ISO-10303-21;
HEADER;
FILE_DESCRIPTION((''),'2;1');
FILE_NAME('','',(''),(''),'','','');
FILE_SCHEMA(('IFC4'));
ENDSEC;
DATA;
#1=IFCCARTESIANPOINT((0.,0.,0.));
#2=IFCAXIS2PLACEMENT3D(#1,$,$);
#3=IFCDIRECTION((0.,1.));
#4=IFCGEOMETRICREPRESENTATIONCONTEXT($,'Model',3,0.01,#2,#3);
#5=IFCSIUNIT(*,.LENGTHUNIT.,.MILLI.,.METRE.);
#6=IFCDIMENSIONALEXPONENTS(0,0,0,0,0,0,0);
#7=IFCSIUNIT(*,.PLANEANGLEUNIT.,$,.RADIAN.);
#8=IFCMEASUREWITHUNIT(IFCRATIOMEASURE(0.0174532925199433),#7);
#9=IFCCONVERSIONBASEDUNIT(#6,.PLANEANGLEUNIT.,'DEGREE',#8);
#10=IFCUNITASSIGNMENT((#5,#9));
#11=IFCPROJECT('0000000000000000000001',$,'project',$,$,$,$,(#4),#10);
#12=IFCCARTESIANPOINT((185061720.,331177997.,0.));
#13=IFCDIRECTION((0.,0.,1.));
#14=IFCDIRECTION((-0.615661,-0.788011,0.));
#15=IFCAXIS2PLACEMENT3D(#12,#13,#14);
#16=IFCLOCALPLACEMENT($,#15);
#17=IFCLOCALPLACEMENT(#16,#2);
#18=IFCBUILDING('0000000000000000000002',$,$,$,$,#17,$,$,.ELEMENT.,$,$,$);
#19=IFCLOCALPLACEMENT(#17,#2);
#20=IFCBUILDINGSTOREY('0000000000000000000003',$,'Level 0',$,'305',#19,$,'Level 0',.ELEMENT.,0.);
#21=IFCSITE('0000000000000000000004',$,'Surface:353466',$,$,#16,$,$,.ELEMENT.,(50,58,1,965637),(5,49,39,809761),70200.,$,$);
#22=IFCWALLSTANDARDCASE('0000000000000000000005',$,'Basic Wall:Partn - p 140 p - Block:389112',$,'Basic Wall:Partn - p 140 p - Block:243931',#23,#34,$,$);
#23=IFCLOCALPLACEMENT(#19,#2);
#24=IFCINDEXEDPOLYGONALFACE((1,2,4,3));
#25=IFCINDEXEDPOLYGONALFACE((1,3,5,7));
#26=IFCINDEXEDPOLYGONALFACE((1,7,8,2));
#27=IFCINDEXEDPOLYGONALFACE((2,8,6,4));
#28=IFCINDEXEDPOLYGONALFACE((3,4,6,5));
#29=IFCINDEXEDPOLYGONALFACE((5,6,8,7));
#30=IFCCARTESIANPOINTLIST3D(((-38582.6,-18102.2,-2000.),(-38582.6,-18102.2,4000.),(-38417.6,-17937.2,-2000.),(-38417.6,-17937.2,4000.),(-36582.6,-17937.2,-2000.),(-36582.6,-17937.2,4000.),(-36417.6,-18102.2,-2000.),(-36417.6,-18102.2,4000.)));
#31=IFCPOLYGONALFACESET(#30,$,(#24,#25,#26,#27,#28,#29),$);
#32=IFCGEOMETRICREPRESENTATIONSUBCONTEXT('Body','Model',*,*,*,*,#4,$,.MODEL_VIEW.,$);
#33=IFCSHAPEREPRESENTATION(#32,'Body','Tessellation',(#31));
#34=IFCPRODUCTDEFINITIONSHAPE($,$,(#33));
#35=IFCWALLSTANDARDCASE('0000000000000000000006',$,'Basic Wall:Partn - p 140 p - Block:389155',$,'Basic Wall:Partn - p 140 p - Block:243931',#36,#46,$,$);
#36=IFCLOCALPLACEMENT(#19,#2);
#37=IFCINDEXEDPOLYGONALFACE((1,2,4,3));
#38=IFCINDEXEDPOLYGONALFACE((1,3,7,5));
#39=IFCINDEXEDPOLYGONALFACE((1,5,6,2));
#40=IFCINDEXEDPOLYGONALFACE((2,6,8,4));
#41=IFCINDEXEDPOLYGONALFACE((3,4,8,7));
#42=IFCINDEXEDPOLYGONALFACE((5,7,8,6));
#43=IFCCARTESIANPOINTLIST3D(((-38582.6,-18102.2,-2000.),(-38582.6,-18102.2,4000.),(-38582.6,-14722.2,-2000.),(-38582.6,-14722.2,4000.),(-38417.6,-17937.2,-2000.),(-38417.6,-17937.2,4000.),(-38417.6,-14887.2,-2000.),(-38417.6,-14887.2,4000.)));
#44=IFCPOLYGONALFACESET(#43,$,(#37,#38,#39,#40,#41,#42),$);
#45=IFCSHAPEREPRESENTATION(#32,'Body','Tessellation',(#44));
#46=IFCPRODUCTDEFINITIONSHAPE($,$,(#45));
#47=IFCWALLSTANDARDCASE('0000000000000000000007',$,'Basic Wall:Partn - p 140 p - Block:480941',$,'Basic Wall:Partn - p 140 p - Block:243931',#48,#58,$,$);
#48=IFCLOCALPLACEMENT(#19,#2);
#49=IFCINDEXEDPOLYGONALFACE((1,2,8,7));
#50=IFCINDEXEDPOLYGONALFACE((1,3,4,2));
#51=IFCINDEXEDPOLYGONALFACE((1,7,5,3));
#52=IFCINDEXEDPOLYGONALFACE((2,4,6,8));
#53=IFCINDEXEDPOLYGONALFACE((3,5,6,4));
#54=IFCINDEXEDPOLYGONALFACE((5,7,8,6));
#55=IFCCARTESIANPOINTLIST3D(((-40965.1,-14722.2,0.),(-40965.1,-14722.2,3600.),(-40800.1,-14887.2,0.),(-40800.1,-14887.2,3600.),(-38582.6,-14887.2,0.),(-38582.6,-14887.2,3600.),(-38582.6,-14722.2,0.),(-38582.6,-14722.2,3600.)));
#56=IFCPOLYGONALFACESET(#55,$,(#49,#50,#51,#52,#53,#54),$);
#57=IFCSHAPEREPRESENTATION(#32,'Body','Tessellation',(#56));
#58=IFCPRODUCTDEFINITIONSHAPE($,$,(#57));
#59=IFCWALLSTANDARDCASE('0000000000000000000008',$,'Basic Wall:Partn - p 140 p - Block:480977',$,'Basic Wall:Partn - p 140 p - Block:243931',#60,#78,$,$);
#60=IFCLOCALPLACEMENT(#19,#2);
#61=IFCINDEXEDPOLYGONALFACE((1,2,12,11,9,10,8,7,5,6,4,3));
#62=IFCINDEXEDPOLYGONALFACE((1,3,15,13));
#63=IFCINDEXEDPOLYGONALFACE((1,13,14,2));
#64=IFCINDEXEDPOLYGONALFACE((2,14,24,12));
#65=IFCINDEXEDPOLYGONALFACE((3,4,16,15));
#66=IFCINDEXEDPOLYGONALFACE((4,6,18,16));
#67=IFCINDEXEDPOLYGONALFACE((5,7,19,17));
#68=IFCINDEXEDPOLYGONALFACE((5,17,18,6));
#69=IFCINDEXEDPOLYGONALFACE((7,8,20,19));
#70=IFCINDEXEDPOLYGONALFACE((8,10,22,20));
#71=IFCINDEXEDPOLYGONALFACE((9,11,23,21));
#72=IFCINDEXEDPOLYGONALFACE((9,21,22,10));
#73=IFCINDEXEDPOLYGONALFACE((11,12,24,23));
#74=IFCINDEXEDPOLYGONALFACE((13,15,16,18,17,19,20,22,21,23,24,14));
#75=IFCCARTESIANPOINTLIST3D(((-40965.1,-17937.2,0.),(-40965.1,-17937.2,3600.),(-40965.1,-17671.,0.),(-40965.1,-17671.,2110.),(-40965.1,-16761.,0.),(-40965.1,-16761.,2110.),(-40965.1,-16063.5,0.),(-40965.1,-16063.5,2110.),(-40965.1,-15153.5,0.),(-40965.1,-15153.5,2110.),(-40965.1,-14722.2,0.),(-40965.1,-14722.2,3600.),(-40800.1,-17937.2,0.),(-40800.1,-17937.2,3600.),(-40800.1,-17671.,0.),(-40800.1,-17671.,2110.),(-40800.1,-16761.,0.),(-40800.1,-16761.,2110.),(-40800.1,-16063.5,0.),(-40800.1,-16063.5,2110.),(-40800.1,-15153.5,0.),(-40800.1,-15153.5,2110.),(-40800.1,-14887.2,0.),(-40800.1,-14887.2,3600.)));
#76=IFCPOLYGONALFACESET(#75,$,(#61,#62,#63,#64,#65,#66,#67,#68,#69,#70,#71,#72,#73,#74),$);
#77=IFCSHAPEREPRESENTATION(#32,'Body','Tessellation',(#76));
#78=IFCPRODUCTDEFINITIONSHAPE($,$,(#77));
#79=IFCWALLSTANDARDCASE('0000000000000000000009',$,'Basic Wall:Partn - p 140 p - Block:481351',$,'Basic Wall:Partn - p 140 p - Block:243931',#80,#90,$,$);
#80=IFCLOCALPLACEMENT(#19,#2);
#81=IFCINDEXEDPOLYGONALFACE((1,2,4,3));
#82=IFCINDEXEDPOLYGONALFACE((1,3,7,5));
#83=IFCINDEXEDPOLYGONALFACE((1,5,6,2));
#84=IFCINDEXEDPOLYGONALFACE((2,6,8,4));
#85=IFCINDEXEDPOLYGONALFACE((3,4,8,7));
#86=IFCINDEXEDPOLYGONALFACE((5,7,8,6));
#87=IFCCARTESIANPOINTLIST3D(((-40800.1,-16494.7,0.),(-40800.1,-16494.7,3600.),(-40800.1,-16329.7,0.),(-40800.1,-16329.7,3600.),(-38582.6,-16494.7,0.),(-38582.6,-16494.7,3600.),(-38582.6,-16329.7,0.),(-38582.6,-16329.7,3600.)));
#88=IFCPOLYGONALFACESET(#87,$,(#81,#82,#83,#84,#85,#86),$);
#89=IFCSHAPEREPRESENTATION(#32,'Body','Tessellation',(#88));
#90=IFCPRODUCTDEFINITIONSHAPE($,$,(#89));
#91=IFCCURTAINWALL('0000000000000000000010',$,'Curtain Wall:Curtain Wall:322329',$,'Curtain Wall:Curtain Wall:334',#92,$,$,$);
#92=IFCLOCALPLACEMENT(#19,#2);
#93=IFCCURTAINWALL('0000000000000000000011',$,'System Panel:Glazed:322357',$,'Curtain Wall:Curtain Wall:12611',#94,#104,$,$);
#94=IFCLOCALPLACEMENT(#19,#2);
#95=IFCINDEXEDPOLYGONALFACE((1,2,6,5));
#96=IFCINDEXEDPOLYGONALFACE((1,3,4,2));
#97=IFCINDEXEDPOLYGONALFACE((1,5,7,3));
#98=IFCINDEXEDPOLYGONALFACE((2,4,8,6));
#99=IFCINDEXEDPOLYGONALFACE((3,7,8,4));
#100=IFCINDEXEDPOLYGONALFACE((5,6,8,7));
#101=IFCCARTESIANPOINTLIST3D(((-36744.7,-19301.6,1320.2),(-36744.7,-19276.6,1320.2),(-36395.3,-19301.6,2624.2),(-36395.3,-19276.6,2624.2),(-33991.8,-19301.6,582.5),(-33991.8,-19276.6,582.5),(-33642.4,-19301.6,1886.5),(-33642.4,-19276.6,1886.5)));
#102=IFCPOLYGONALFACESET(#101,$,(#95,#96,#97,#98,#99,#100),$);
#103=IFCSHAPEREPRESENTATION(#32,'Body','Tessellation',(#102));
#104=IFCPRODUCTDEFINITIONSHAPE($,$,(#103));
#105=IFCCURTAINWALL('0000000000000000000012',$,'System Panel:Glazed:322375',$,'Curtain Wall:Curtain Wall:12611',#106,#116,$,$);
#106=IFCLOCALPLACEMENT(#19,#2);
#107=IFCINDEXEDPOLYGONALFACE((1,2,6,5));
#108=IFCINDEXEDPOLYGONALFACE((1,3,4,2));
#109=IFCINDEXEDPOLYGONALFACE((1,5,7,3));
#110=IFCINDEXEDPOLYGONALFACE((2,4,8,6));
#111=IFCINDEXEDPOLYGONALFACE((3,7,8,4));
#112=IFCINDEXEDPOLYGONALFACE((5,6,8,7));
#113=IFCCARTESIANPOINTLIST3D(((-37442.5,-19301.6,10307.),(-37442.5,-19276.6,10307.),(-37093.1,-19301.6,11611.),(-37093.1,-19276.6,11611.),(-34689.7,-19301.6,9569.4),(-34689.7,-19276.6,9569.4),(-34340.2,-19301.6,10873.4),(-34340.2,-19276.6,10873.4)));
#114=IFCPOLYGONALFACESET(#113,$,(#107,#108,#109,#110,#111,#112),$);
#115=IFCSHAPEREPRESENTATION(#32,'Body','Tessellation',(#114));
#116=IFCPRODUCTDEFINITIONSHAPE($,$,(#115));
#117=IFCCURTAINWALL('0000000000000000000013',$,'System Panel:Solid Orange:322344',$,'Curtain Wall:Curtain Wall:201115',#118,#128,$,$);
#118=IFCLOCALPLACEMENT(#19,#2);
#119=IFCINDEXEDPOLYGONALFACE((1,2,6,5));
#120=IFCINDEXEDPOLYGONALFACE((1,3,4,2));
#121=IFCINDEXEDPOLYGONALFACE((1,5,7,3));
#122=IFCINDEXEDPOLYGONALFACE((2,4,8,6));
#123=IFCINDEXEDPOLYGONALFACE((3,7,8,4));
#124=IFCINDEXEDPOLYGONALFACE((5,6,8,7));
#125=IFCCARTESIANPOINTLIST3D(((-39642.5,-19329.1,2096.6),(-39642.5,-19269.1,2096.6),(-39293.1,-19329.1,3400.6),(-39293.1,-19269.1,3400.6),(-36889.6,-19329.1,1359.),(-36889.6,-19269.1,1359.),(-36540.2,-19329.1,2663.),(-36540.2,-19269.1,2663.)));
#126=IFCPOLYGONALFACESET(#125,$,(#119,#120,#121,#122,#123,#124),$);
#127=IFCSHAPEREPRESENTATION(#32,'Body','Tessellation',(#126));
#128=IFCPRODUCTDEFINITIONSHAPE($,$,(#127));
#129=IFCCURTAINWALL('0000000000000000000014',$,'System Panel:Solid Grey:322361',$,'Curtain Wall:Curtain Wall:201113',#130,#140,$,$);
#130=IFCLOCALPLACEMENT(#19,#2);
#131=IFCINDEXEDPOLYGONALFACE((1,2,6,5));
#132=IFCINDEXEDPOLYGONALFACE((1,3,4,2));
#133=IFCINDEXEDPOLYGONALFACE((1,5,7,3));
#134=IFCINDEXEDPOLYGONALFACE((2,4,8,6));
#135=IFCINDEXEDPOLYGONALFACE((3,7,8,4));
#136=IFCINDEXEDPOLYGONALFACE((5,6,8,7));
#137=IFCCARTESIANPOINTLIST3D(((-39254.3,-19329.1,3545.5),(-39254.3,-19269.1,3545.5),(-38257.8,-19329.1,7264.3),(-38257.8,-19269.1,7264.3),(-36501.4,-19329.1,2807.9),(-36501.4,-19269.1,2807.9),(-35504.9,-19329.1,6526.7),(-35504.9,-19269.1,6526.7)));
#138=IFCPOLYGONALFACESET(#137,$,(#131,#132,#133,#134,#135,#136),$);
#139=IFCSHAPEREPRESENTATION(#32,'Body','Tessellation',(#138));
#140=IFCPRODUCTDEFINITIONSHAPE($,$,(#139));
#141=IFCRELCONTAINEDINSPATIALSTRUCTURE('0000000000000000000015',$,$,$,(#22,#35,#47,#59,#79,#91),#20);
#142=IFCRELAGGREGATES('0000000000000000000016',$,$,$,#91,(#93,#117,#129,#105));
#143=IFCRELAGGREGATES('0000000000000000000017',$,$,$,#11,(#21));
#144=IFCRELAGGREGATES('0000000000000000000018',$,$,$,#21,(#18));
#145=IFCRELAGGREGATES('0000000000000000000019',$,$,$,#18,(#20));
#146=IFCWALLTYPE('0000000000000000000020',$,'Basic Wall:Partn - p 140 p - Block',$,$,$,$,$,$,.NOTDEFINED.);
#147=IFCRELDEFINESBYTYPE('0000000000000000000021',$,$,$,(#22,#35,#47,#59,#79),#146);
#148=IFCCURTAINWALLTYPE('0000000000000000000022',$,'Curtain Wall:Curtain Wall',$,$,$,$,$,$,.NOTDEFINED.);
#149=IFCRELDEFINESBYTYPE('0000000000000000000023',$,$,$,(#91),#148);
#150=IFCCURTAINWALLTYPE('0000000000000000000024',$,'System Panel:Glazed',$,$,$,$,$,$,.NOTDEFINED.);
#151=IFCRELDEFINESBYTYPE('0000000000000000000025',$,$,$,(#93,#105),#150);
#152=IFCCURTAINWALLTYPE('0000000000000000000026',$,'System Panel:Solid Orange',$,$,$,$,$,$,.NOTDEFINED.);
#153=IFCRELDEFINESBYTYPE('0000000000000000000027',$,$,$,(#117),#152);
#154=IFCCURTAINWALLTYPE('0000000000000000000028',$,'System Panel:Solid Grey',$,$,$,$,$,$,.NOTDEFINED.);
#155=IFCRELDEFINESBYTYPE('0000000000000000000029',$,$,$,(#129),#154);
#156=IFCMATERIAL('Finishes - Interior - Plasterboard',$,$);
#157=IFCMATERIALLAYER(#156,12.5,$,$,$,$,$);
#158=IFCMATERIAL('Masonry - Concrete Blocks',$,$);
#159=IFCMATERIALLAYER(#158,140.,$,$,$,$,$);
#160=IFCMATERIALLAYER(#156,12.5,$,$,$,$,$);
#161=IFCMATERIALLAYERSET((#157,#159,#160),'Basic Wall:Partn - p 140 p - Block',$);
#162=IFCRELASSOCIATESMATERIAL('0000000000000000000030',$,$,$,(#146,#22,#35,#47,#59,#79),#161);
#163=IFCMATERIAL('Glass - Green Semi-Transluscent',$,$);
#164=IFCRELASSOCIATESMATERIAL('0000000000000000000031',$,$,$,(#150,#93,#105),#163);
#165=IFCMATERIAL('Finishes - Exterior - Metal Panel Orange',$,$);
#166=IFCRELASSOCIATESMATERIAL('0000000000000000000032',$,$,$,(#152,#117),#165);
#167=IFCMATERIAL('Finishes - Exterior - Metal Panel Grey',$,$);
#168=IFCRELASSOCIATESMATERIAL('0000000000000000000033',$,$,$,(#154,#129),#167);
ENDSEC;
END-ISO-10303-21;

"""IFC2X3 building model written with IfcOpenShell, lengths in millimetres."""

from ifc_helpers import new_model, entity, si_unit, converted_unit, direction, frame, frame_2d, origin, place, context, subcontext, project, spatial, polyline, rectangle, outline, extrude, clip, halfspace, bounded_halfspace, source, transform, mapped, material, layer, layer_set, layer_usage, type_object, type_shapes, element, aggregate, save


model = new_model("IFC2X3")

# Units and contexts
model_context = context("Model", 3, precision=0.01, world=origin(), true_north=direction((0.0, 1.0)))
body_context = subcontext(model_context, "Body", "Model", "MODEL_VIEW")
ifc_project = project(units=[si_unit("LENGTHUNIT", "METRE", prefix="MILLI"), converted_unit("PLANEANGLEUNIT", "DEGREE", entity("IfcRatioMeasure", 0.0174532925199433), si_unit("PLANEANGLEUNIT", "RADIAN"), dimensions=[0, 0, 0, 0, 0, 0, 0])], contexts=[model_context])

# Site, building, storey
site_placement = place(None, frame((185061720.0, 331177997.0, 0.0), z_axis=(0.0, 0.0, 1.0), x_axis=(-0.615661, -0.788011, 0.0)))
site = spatial("IfcSite", under=ifc_project, at=site_placement, Name="Surface:353466", CompositionType="ELEMENT", RefLatitude=(50, 58, 1, 965637), RefLongitude=(5, 49, 39, 809761), RefElevation=70200.0)
building_placement = place(site_placement, origin())
building = spatial("IfcBuilding", under=site, at=building_placement, CompositionType="ELEMENT")
storey_placement = place(building_placement, origin())
storey = spatial("IfcBuildingStorey", under=building, at=storey_placement, Name="Level 0", ObjectType="305", LongName="Level 0", CompositionType="ELEMENT", Elevation=0.0)

# Walls
ifc_material_1 = material(Name="Finishes - Interior - Plasterboard")
ifc_layer_1 = layer(ifc_material_1, 12.5)
ifc_material_2 = material(Name="Masonry - Concrete Blocks")
ifc_layer_2 = layer(ifc_material_2, 140.0)
ifc_layer_3 = layer(ifc_material_1, 12.5)
ifc_layer_set = layer_set([ifc_layer_1, ifc_layer_2, ifc_layer_3], Name="Basic Wall:Partn - p 140 p - Block")
ifc_layer_usage_1 = layer_usage(ifc_layer_set, "AXIS2", "NEGATIVE", 82.5)
wall_type = type_object("IfcWallType", Name="Basic Wall:Partn - p 140 p - Block", PredefinedType="NOTDEFINED", material=ifc_layer_set)
wall_1_placement = place(storey_placement, frame((-36417.6, -18019.7, -2000.0), z_axis=(0.0, 0.0, 1.0), x_axis=(-1.0, 0.0, 0.0)))
element("IfcWallStandardCase", 1, at=wall_1_placement, inside=storey, type_object=wall_type, material=ifc_layer_usage_1, Name="Basic Wall:Partn - p 140 p - Block:389112", ObjectType="Basic Wall:Partn - p 140 p - Block:243931", context=body_context, shape_type="Clipping", body=[
    clip(extrude(outline(polyline([(2000.0, -82.5), (2165.0, 82.5), (0.0, 82.5), (165.0, -82.5), (2000.0, -82.5)])), origin(), (0.0, 0.0, 1.0), 6000.0), halfspace(frame((0.0, 0.0, -2000.0)), True)),
])
ifc_layer_usage_2 = layer_usage(ifc_layer_set, "AXIS2", "NEGATIVE", 82.5)
wall_2_placement = place(storey_placement, frame((-38500.1, -18102.2, -2000.0), z_axis=(0.0, 0.0, 1.0), x_axis=(0.0, 1.0, 0.0)))
element("IfcWallStandardCase", 2, at=wall_2_placement, inside=storey, type_object=wall_type, material=ifc_layer_usage_2, Name="Basic Wall:Partn - p 140 p - Block:389155", ObjectType="Basic Wall:Partn - p 140 p - Block:243931", context=body_context, shape_type="Clipping", body=[
    clip(extrude(outline(polyline([(3215.0, -82.5), (3380.0, 82.5), (0.0, 82.5), (165.0, -82.5), (3215.0, -82.5)])), origin(), (0.0, 0.0, 1.0), 6000.0), halfspace(frame((0.0, 0.0, -2000.0)), True)),
])
ifc_layer_usage_3 = layer_usage(ifc_layer_set, "AXIS2", "NEGATIVE", 82.5)
wall_3_placement = place(storey_placement, frame((-38582.6, -14804.7, 0.0), z_axis=(0.0, 0.0, 1.0), x_axis=(-1.0, 0.0, 0.0)))
element("IfcWallStandardCase", 3, at=wall_3_placement, inside=storey, type_object=wall_type, material=ifc_layer_usage_3, Name="Basic Wall:Partn - p 140 p - Block:480941", ObjectType="Basic Wall:Partn - p 140 p - Block:243931", context=body_context, shape_type="Clipping", body=[
    clip(extrude(outline(polyline([(2382.5, -82.5), (2217.5, 82.5), (0.0, 82.5), (0.0, -82.5), (2382.5, -82.5)])), origin(), (0.0, 0.0, 1.0), 3600.0), bounded_halfspace(frame((0.0, -82.5, 3600.0), z_axis=(0.0, 0.0, -1.0), x_axis=(-1.0, 0.0, 0.0)), True, frame((0.0, -82.5, 3600.0)), polyline([(0.0, 0.0), (2382.5, 0.0), (2217.5, 165.0), (0.0, 165.0), (0.0, 0.0)]))),
])

# Wall, openings
ifc_layer_usage_4 = layer_usage(ifc_layer_set, "AXIS2", "NEGATIVE", 82.5)
wall_4_placement = place(storey_placement, frame((-40882.6, -14722.2, 0.0), z_axis=(0.0, 0.0, 1.0), x_axis=(0.0, -1.0, 0.0)))
wall_4 = element("IfcWallStandardCase", 4, at=wall_4_placement, inside=storey, type_object=wall_type, material=ifc_layer_usage_4, Name="Basic Wall:Partn - p 140 p - Block:480977", ObjectType="Basic Wall:Partn - p 140 p - Block:243931", context=body_context, shape_type="Clipping", body=[
    clip(extrude(outline(polyline([(3215.0, 82.5), (1772.5, 82.5), (1607.5, 82.5), (165.0, 82.5), (0.0, -82.5), (3215.0, -82.5), (3215.0, 82.5)])), origin(), (0.0, 0.0, 1.0), 3600.0), bounded_halfspace(frame((3215.0, 82.5, 3600.0), z_axis=(0.0, 0.0, -1.0), x_axis=(0.0, 1.0, 0.0)), True, frame((3215.0, 82.5, 3600.0)), polyline([(0.0, 0.0), (-1442.5, 0.0), (-1607.5, 0.0), (-3050.0, 0.0), (-3215.0, -165.0), (0.0, -165.0), (0.0, 0.0)]))),
])
opening_1_placement = place(wall_4_placement, origin())
element("IfcOpeningElement", 5, at=opening_1_placement, cuts=wall_4, ObjectType="Opening", context=body_context, shape_type="SweptSolid", body=[
    extrude(rectangle(XDim=2110.0, YDim=910.0, at=frame_2d((0.0, 0.0), x_axis=(0.0, 1.0))), frame((886.2, -1606.5, 1055.0), z_axis=(0.0, 1.0, 0.0), x_axis=(-1.0, 0.0, 0.0)), (0.0, 0.0, 1.0), 3048.0),
])
opening_2_placement = place(wall_4_placement, origin())
element("IfcOpeningElement", 6, at=opening_2_placement, cuts=wall_4, ObjectType="Opening", context=body_context, shape_type="SweptSolid", body=[
    extrude(rectangle(XDim=2110.0, YDim=910.0, at=frame_2d((0.0, 0.0), x_axis=(1.0, 0.0))), frame((2493.8, -1606.5, 1055.0), z_axis=(0.0, 1.0, 0.0), x_axis=(0.0, 0.0, 1.0)), (0.0, 0.0, 1.0), 3048.0),
])
opening_3_placement = place(wall_4_placement, frame((431.2, -82.5, 0.0)))
element("IfcOpeningElement", 7, at=opening_3_placement, cuts=wall_4, ObjectType="Opening", context=body_context, shape_type="SweptSolid", body=[
    extrude(rectangle(XDim=2110.0, YDim=910.0, at=frame_2d((1055.0, 455.0), x_axis=(1.0, 0.0))), frame((0.0, 0.0, 0.0), z_axis=(0.0, 1.0, 0.0), x_axis=(0.0, 0.0, 1.0)), (0.0, 0.0, 1.0), 165.0),
])
opening_4_placement = place(wall_4_placement, frame((2038.8, -82.5, 0.0)))
element("IfcOpeningElement", 8, at=opening_4_placement, cuts=wall_4, ObjectType="Opening", context=body_context, shape_type="SweptSolid", body=[
    extrude(rectangle(XDim=2110.0, YDim=910.0, at=frame_2d((1055.0, 455.0), x_axis=(1.0, 0.0))), frame((0.0, 0.0, 0.0), z_axis=(0.0, 1.0, 0.0), x_axis=(0.0, 0.0, 1.0)), (0.0, 0.0, 1.0), 165.0),
])

# Wall
ifc_layer_usage_5 = layer_usage(ifc_layer_set, "AXIS2", "NEGATIVE", 82.5)
wall_5_placement = place(storey_placement, frame((-38582.6, -16412.2, 0.0), z_axis=(0.0, 0.0, 1.0), x_axis=(-1.0, 0.0, 0.0)))
element("IfcWallStandardCase", 9, at=wall_5_placement, inside=storey, type_object=wall_type, material=ifc_layer_usage_5, Name="Basic Wall:Partn - p 140 p - Block:481351", ObjectType="Basic Wall:Partn - p 140 p - Block:243931", context=body_context, shape_type="Clipping", body=[
    clip(extrude(rectangle(XDim=2217.5, YDim=165.0, at=frame_2d((1108.8, 0.0), x_axis=(-1.0, 0.0))), origin(), (0.0, 0.0, 1.0), 3600.0), bounded_halfspace(frame((0.0, -82.5, 3600.0), z_axis=(0.0, 0.0, -1.0), x_axis=(-1.0, 0.0, 0.0)), True, frame((0.0, -82.5, 3600.0)), polyline([(0.0, 0.0), (2217.5, 0.0), (2217.5, 165.0), (0.0, 165.0), (0.0, 0.0)]))),
])

# Curtain walls
curtain_wall_type_1 = type_object("IfcCurtainWallType", Name="Curtain Wall:Curtain Wall", PredefinedType="NOTDEFINED")
curtain_wall_1_placement = place(storey_placement, origin())
curtain_wall_1 = element("IfcCurtainWall", 10, at=curtain_wall_1_placement, inside=storey, type_object=curtain_wall_type_1, Name="Curtain Wall:Curtain Wall:322329", ObjectType="Curtain Wall:Curtain Wall:334")
ifc_material_3 = material(Name="Glass - Green Semi-Transluscent")
curtain_wall_type_2 = type_object("IfcCurtainWallType", Name="System Panel:Glazed", PredefinedType="NOTDEFINED", material=ifc_material_3)
shared_shape_1 = source(origin(), body_context, "Body", "SweptSolid", [
    extrude(rectangle(XDim=25.0, YDim=2850.0, at=frame_2d((0.0, 0.0), x_axis=(1.0, 0.0))), frame((0.0, -10.0, 0.0), z_axis=(0.0, 0.0, 1.0), x_axis=(0.0, 1.0, 0.0)), (0.0, 0.0, 1.0), 1350.0),
])
type_shapes(curtain_wall_type_2, [shared_shape_1])
curtain_wall_2_placement = place(storey_placement, frame((-35368.3, -19299.1, 951.4), z_axis=(0.258819, 0.0, 0.965926), x_axis=(-0.965926, 0.0, 0.258819)))
curtain_wall_2 = element("IfcCurtainWall", 11, at=curtain_wall_2_placement, type_object=curtain_wall_type_2, material=ifc_material_3, Name="System Panel:Glazed:322357", ObjectType="Curtain Wall:Curtain Wall:12611", context=body_context, shape_type="MappedRepresentation", body=[
    mapped(shared_shape_1, transform((0.0, 0.0, 0.0), scale=1.0)),
])
curtain_wall_3_placement = place(storey_placement, frame((-36066.1, -19299.1, 9938.2), z_axis=(0.258819, 0.0, 0.965926), x_axis=(-0.965926, 0.0, 0.258819)))
curtain_wall_3 = element("IfcCurtainWall", 12, at=curtain_wall_3_placement, type_object=curtain_wall_type_2, material=ifc_material_3, Name="System Panel:Glazed:322375", ObjectType="Curtain Wall:Curtain Wall:12611", context=body_context, shape_type="MappedRepresentation", body=[
    mapped(shared_shape_1, transform((0.0, 0.0, 0.0), scale=1.0)),
])
ifc_material_4 = material(Name="Finishes - Exterior - Metal Panel Orange")
curtain_wall_type_3 = type_object("IfcCurtainWallType", Name="System Panel:Solid Orange", PredefinedType="NOTDEFINED", material=ifc_material_4)
shared_shape_2 = source(origin(), body_context, "Body", "SweptSolid", [
    extrude(rectangle(XDim=60.0, YDim=2850.0, at=frame_2d((0.0, 0.0), x_axis=(1.0, 0.0))), frame((0.0, 0.0, 0.0), z_axis=(0.0, 0.0, 1.0), x_axis=(0.0, 1.0, 0.0)), (0.0, 0.0, 1.0), 1350.0),
])
type_shapes(curtain_wall_type_3, [shared_shape_2])
curtain_wall_4_placement = place(storey_placement, frame((-38266.1, -19299.1, 1727.8), z_axis=(0.258819, 0.0, 0.965926), x_axis=(-0.965926, 0.0, 0.258819)))
curtain_wall_4 = element("IfcCurtainWall", 13, at=curtain_wall_4_placement, type_object=curtain_wall_type_3, material=ifc_material_4, Name="System Panel:Solid Orange:322344", ObjectType="Curtain Wall:Curtain Wall:201115", context=body_context, shape_type="MappedRepresentation", body=[
    mapped(shared_shape_2, transform((0.0, 0.0, 0.0), scale=1.0)),
])
ifc_material_5 = material(Name="Finishes - Exterior - Metal Panel Grey")
curtain_wall_type_4 = type_object("IfcCurtainWallType", Name="System Panel:Solid Grey", PredefinedType="NOTDEFINED", material=ifc_material_5)
shared_shape_3 = source(origin(), body_context, "Body", "SweptSolid", [
    extrude(rectangle(XDim=60.0, YDim=2850.0, at=frame_2d((0.0, 0.0), x_axis=(1.0, 0.0))), frame((0.0, 0.0, 0.0), z_axis=(0.0, 0.0, 1.0), x_axis=(0.0, 1.0, 0.0)), (0.0, 0.0, 1.0), 3850.0),
])
type_shapes(curtain_wall_type_4, [shared_shape_3])
curtain_wall_5_placement = place(storey_placement, frame((-37877.8, -19299.1, 3176.7), z_axis=(0.258819, 0.0, 0.965926), x_axis=(-0.965926, 0.0, 0.258819)))
curtain_wall_5 = element("IfcCurtainWall", 14, at=curtain_wall_5_placement, type_object=curtain_wall_type_4, material=ifc_material_5, Name="System Panel:Solid Grey:322361", ObjectType="Curtain Wall:Curtain Wall:201113", context=body_context, shape_type="MappedRepresentation", body=[
    mapped(shared_shape_3, transform((0.0, 0.0, 0.0), scale=1.0)),
])
aggregate(curtain_wall_1, [curtain_wall_2, curtain_wall_4, curtain_wall_5, curtain_wall_3])

save(model, "model.ifc")
